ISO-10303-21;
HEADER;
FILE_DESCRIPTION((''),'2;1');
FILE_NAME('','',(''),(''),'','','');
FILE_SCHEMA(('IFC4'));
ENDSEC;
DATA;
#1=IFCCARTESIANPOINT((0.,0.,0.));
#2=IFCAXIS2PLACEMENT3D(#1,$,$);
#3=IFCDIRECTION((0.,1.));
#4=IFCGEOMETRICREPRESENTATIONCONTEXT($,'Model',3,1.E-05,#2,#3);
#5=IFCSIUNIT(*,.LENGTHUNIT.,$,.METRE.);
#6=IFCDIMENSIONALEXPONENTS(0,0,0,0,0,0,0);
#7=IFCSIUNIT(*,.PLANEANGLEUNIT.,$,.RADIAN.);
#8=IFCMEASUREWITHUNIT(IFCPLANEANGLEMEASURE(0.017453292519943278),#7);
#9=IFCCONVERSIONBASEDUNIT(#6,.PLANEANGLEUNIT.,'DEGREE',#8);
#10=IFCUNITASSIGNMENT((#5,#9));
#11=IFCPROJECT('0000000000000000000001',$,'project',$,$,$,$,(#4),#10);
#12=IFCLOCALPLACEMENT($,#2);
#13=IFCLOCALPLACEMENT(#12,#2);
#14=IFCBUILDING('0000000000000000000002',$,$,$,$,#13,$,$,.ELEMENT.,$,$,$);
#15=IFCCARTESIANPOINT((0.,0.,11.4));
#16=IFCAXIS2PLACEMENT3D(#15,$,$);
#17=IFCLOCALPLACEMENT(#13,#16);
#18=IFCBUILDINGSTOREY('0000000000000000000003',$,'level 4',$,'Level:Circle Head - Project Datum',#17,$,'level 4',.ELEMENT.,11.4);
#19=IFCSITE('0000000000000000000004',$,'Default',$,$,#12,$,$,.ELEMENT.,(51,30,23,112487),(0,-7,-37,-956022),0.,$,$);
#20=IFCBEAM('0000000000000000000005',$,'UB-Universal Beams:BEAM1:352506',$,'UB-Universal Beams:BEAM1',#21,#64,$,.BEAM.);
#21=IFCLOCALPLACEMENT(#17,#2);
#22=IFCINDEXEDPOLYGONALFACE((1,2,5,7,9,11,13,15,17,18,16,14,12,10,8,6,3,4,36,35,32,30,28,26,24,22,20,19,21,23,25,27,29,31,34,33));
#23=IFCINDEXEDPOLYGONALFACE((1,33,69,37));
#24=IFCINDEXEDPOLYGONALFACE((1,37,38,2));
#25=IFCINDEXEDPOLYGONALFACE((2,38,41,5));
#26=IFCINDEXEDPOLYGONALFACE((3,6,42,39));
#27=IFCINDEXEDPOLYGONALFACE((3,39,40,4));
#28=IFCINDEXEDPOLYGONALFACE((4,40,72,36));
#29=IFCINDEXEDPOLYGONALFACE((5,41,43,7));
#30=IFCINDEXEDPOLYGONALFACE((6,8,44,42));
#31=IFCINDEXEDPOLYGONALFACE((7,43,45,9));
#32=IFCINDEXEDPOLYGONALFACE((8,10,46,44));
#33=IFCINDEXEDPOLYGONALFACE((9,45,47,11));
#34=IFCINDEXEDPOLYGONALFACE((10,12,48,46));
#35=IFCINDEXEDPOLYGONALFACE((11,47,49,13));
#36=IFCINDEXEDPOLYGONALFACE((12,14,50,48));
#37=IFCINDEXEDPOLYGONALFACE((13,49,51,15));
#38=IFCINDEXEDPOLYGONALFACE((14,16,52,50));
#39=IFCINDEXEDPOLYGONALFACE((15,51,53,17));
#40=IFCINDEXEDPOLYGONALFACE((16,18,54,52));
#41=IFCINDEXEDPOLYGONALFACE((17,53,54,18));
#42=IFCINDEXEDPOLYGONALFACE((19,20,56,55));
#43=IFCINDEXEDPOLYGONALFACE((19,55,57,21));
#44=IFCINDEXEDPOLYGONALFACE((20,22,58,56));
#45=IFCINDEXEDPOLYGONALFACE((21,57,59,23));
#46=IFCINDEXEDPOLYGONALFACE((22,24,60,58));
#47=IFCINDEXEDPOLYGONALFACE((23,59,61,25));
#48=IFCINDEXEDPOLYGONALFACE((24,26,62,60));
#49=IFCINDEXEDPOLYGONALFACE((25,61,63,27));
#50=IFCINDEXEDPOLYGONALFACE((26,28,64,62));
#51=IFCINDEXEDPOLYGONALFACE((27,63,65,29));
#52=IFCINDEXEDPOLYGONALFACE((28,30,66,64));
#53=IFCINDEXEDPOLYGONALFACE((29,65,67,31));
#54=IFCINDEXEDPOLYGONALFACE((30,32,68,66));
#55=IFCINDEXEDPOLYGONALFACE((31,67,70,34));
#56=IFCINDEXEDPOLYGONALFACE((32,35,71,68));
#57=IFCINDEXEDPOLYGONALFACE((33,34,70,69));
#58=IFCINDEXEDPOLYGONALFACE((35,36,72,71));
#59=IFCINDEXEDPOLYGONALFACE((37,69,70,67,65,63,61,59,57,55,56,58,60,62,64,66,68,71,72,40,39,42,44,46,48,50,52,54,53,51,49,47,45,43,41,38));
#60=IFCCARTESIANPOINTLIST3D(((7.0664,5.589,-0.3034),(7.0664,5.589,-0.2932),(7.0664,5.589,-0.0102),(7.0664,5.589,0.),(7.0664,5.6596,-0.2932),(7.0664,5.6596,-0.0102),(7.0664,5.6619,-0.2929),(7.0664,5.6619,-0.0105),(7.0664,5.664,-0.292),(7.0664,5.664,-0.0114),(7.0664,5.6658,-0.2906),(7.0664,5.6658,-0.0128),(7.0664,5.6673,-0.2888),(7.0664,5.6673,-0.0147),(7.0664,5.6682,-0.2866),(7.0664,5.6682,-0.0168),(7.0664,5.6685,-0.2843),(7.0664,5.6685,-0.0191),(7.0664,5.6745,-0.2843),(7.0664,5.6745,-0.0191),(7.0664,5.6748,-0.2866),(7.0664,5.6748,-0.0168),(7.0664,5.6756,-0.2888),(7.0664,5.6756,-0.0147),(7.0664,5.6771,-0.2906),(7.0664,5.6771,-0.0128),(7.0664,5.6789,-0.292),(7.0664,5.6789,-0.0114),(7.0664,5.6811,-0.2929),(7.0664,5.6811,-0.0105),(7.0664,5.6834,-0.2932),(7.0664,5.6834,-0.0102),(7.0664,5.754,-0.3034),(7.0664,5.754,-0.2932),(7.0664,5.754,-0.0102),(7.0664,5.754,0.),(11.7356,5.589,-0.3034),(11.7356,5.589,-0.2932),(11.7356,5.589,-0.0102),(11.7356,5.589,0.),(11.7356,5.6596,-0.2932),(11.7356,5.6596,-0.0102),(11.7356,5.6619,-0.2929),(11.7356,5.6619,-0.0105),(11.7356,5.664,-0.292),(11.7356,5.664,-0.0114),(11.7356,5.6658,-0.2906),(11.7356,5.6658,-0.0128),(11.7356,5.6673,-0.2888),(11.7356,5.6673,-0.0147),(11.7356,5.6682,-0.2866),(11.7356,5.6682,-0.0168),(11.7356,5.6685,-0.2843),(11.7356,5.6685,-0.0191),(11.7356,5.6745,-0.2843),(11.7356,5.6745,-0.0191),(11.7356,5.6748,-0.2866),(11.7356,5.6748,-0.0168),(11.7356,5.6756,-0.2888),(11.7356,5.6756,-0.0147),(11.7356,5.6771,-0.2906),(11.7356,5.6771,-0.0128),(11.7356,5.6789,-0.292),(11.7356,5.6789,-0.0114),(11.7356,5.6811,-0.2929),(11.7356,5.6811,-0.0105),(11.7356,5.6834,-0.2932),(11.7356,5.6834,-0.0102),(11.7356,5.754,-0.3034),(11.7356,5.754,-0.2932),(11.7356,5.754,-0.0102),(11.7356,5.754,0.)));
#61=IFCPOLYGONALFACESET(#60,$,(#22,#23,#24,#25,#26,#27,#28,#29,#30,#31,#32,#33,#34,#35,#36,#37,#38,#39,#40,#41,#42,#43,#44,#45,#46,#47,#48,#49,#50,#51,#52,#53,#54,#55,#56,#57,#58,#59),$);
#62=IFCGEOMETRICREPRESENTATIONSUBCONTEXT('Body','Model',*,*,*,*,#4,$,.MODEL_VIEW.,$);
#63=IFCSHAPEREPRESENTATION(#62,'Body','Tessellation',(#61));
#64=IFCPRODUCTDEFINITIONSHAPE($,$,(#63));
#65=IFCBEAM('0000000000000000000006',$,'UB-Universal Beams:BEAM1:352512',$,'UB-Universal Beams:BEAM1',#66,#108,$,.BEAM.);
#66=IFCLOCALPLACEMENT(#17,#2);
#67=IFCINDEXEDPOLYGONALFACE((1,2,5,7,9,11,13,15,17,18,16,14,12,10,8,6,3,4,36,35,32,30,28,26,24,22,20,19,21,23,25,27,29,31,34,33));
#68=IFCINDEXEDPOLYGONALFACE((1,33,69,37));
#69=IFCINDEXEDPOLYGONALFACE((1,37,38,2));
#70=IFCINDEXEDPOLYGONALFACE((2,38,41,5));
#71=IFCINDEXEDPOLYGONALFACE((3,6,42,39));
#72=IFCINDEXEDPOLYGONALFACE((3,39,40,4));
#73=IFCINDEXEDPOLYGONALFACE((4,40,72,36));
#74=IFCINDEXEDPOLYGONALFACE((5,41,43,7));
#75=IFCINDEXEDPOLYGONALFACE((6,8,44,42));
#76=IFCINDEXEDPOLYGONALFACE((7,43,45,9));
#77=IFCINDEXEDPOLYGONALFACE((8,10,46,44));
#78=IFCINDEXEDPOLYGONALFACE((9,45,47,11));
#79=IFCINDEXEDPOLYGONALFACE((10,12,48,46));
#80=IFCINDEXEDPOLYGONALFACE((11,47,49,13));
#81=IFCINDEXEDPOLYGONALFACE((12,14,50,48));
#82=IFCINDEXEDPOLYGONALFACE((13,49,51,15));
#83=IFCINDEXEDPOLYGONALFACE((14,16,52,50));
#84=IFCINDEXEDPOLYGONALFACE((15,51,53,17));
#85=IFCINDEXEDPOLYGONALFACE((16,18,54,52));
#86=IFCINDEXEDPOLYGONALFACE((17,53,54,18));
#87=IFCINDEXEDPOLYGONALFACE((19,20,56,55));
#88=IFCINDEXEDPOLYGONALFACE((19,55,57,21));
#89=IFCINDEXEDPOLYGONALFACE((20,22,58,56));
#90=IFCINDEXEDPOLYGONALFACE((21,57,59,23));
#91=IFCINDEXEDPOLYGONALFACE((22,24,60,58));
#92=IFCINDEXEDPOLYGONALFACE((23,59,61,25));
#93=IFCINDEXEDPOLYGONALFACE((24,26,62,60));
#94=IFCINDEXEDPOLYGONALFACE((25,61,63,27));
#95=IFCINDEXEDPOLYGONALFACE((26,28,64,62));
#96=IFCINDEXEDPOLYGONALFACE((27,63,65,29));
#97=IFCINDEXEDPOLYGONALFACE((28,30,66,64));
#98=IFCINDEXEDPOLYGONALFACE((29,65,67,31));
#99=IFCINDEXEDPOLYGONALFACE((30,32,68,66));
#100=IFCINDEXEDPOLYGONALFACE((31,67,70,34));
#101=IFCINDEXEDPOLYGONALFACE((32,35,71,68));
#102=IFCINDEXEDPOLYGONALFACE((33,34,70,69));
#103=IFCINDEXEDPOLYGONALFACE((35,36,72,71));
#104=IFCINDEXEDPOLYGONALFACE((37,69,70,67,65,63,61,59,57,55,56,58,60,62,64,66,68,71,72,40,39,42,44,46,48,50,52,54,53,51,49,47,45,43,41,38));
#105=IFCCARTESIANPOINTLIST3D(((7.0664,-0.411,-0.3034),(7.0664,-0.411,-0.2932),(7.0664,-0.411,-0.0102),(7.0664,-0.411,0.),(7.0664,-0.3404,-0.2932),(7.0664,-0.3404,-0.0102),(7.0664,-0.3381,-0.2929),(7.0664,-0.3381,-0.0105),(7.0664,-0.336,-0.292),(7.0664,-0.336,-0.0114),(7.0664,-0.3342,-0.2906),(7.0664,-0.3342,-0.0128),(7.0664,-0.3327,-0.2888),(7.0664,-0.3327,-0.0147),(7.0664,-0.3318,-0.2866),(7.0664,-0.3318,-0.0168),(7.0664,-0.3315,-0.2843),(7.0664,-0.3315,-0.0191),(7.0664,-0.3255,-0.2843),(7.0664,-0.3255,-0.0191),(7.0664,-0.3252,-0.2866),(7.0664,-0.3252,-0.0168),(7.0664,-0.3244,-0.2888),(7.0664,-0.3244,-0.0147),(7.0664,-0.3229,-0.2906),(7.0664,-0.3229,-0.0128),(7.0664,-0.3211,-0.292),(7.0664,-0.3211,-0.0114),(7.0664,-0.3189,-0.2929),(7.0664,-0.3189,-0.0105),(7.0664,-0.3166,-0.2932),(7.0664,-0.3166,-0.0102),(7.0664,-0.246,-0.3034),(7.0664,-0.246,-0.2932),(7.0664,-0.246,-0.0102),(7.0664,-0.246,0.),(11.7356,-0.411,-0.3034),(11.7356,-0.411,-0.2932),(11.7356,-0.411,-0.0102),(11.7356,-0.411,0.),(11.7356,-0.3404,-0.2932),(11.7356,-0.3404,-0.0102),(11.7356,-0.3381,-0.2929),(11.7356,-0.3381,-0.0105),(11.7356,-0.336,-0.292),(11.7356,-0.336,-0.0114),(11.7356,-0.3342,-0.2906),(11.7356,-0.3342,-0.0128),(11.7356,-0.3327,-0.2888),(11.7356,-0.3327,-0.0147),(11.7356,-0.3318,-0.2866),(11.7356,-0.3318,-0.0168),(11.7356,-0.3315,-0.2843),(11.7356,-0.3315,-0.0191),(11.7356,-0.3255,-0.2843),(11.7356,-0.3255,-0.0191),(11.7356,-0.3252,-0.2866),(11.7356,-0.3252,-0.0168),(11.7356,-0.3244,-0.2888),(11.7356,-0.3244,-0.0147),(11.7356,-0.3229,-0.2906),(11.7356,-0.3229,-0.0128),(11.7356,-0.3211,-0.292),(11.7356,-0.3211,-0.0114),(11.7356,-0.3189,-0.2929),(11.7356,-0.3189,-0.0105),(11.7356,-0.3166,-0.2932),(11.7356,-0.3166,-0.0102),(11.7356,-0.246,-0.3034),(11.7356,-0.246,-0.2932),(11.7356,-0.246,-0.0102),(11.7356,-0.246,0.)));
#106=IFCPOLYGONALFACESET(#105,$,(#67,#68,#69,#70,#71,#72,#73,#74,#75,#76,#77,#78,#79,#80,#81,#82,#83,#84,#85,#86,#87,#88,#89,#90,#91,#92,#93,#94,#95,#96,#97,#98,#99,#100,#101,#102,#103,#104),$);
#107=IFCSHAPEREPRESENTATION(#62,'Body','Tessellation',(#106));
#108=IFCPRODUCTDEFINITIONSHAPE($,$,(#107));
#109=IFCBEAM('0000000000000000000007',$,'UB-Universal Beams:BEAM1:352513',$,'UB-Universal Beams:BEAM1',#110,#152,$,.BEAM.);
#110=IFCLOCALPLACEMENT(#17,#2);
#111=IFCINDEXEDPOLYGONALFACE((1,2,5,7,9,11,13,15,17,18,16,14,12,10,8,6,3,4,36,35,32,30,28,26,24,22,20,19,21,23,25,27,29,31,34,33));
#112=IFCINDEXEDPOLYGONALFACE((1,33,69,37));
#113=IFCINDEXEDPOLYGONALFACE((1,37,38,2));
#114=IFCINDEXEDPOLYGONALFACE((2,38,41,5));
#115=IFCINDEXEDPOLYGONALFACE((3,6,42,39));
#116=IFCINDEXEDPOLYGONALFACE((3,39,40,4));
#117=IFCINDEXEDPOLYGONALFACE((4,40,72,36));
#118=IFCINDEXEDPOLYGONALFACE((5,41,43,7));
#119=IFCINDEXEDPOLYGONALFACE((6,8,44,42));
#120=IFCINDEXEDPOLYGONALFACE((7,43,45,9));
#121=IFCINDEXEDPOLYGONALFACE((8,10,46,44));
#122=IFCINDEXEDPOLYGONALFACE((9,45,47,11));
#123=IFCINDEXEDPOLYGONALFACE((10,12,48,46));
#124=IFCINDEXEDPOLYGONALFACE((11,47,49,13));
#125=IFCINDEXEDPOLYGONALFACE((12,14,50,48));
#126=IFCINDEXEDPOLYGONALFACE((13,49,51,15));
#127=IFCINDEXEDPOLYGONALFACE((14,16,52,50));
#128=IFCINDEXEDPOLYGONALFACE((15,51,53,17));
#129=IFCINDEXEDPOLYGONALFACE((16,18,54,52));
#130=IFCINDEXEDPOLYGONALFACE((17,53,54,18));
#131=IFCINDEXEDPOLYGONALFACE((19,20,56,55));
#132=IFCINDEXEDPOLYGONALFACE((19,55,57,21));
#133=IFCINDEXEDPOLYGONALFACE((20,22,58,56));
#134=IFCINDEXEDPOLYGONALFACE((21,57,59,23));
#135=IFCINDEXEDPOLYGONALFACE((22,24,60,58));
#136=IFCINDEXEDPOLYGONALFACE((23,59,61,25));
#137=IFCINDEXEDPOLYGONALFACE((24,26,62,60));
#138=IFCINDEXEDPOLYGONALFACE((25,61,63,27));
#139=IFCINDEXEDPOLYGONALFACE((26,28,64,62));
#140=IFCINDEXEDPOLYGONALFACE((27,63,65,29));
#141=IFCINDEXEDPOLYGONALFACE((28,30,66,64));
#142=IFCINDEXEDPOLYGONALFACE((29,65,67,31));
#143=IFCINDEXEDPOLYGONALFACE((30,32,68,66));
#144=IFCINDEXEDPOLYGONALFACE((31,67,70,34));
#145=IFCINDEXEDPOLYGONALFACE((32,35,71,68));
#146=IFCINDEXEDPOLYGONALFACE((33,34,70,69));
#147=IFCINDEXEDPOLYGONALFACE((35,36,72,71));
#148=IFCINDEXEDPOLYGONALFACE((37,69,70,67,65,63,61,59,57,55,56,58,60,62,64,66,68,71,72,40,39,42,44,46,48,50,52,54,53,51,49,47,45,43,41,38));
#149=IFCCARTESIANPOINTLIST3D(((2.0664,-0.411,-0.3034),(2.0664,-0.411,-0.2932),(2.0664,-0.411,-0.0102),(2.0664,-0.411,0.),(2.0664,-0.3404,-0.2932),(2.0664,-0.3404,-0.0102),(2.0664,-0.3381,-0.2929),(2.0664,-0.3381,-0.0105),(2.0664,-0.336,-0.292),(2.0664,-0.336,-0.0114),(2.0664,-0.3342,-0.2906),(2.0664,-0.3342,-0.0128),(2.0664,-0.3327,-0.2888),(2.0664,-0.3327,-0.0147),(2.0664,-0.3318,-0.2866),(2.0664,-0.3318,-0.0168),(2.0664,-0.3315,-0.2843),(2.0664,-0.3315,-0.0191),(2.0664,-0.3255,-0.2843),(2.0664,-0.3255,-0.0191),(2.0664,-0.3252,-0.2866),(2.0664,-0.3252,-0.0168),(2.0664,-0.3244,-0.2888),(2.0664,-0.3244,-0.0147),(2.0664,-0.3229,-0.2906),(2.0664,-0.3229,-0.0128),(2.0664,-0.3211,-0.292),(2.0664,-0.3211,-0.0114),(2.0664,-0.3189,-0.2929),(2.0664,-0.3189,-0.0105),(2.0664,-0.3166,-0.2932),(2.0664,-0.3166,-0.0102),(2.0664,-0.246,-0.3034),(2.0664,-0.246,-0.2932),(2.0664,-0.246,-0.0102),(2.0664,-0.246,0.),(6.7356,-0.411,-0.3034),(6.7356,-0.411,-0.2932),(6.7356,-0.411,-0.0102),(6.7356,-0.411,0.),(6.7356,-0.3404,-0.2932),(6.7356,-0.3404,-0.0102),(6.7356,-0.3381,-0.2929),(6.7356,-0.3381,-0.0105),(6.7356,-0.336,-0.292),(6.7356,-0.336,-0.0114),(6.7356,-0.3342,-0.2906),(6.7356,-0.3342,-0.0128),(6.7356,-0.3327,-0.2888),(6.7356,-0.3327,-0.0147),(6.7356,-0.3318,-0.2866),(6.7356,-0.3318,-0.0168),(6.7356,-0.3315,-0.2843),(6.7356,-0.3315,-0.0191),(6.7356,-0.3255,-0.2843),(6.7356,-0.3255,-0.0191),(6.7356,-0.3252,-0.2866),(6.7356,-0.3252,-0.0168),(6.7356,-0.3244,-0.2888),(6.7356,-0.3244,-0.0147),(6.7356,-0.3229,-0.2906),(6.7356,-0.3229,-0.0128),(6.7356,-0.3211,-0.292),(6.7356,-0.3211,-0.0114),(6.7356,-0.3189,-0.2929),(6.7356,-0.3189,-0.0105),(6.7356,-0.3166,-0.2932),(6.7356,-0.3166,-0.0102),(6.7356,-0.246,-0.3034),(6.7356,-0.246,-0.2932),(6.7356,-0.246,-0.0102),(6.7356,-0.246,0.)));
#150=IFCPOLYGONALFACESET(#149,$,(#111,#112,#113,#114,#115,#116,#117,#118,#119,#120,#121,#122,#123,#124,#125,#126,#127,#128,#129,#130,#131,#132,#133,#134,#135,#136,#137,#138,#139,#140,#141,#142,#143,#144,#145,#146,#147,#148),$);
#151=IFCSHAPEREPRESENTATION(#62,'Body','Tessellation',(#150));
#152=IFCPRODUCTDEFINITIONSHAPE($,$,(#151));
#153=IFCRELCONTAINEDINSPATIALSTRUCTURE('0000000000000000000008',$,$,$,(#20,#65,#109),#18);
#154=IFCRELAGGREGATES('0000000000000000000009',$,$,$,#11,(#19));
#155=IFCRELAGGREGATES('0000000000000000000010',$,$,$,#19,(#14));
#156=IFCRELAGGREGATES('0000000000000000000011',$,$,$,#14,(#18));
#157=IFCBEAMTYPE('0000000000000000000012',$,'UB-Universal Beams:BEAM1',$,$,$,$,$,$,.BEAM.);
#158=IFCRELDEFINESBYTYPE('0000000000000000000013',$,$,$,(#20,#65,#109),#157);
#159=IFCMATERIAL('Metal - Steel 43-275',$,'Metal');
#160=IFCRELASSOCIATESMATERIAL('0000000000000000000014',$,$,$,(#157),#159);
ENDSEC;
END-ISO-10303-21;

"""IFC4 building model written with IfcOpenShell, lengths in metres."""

from ifc_helpers import new_model, entity, si_unit, converted_unit, direction, frame, frame_2d, origin, place, context, subcontext, project, spatial, polyline, circle_curve, parameter, trimmed, segment, composite_curve, outline, extrude, source, transform, mapped, material, material_profile, profile_set, type_object, type_shapes, element, save


model = new_model("IFC4")

# Units and contexts
model_context = context("Model", 3, precision=1e-05, world=origin(), true_north=direction((0.0, 1.0)))
body_context = subcontext(model_context, "Body", "Model", "MODEL_VIEW")
ifc_project = project(units=[si_unit("LENGTHUNIT", "METRE"), converted_unit("PLANEANGLEUNIT", "DEGREE", entity("IfcPlaneAngleMeasure", 0.017453292519943278), si_unit("PLANEANGLEUNIT", "RADIAN"), dimensions=[0, 0, 0, 0, 0, 0, 0])], contexts=[model_context])

# Site, building, storey
site_placement = place(None, origin())
site = spatial("IfcSite", under=ifc_project, at=site_placement, Name="Default", CompositionType="ELEMENT", RefLatitude=(51, 30, 23, 112487), RefLongitude=(0, -7, -37, -956022), RefElevation=0.0)
building_placement = place(site_placement, origin())
building = spatial("IfcBuilding", under=site, at=building_placement, CompositionType="ELEMENT")
storey_placement = place(building_placement, frame((0.0, 0.0, 11.4)))
storey = spatial("IfcBuildingStorey", under=building, at=storey_placement, Name="level 4", ObjectType="Level:Circle Head - Project Datum", LongName="level 4", CompositionType="ELEMENT", Elevation=11.4)

# Shared definitions
ifc_material_1 = material(Name="Metal - Steel 43-275", Category="Metal")

# Beams
ifc_material_profile_1 = material_profile(ifc_material_1, outline(composite_curve([segment(polyline([(-0.0825, -0.1415), (-0.0825, -0.1517)]), True, "CONTINUOUS"), segment(polyline([(-0.0825, -0.1517), (0.0825, -0.1517)]), True, "CONTINUOUS"), segment(polyline([(0.0825, -0.1517), (0.0825, -0.1415)]), True, "CONTINUOUS"), segment(polyline([(0.0825, -0.1415), (0.0119, -0.1415)]), True, "CONTINUOUS"), segment(trimmed(circle_curve(frame_2d((0.0119, -0.1326), x_axis=(1.0, 0.0)), 0.0089), [parameter(180.0)], [parameter(270.0)], True, "PARAMETER"), False, "CONTINUOUS"), segment(polyline([(0.003, -0.1326), (0.003, 0.1326)]), True, "CONTINUOUS"), segment(trimmed(circle_curve(frame_2d((0.0119, 0.1326), x_axis=(1.0, 0.0)), 0.0089), [parameter(90.0)], [parameter(180.0)], True, "PARAMETER"), False, "CONTINUOUS"), segment(polyline([(0.0119, 0.1415), (0.0825, 0.1415)]), True, "CONTINUOUS"), segment(polyline([(0.0825, 0.1415), (0.0825, 0.1517)]), True, "CONTINUOUS"), segment(polyline([(0.0825, 0.1517), (-0.0825, 0.1517)]), True, "CONTINUOUS"), segment(polyline([(-0.0825, 0.1517), (-0.0825, 0.1415)]), True, "CONTINUOUS"), segment(polyline([(-0.0825, 0.1415), (-0.0119, 0.1415)]), True, "CONTINUOUS"), segment(trimmed(circle_curve(frame_2d((-0.0119, 0.1326), x_axis=(1.0, 0.0)), 0.0089), [parameter(360.0)], [parameter(90.0)], True, "PARAMETER"), False, "CONTINUOUS"), segment(polyline([(-0.003, 0.1326), (-0.003, -0.1326)]), True, "CONTINUOUS"), segment(trimmed(circle_curve(frame_2d((-0.0119, -0.1326), x_axis=(1.0, 0.0)), 0.0089), [parameter(270.0)], [parameter(360.0)], True, "PARAMETER"), False, "CONTINUOUS"), segment(polyline([(-0.0119, -0.1415), (-0.0825, -0.1415)]), True, "CONTINUOUS")], self_intersect=False)), Name="BEAM1")
ifc_profile_set_1 = profile_set([ifc_material_profile_1], Name="BEAM1")
beam_type_1 = type_object("IfcBeamType", Name="UB-Universal Beams:BEAM1", PredefinedType="BEAM", material=ifc_profile_set_1)
shared_shape_1 = source(origin(), body_context, "Body", "SweptSolid", [
    extrude(outline(composite_curve([segment(polyline([(-0.0825, -0.1415), (-0.0825, -0.1517)]), True, "CONTINUOUS"), segment(polyline([(-0.0825, -0.1517), (0.0825, -0.1517)]), True, "CONTINUOUS"), segment(polyline([(0.0825, -0.1517), (0.0825, -0.1415)]), True, "CONTINUOUS"), segment(polyline([(0.0825, -0.1415), (0.0119, -0.1415)]), True, "CONTINUOUS"), segment(trimmed(circle_curve(frame_2d((0.0119, -0.1326), x_axis=(1.0, 0.0)), 0.0089), [parameter(180.0)], [parameter(270.0)], True, "PARAMETER"), False, "CONTINUOUS"), segment(polyline([(0.003, -0.1326), (0.003, 0.1326)]), True, "CONTINUOUS"), segment(trimmed(circle_curve(frame_2d((0.0119, 0.1326), x_axis=(1.0, 0.0)), 0.0089), [parameter(90.0)], [parameter(180.0)], True, "PARAMETER"), False, "CONTINUOUS"), segment(polyline([(0.0119, 0.1415), (0.0825, 0.1415)]), True, "CONTINUOUS"), segment(polyline([(0.0825, 0.1415), (0.0825, 0.1517)]), True, "CONTINUOUS"), segment(polyline([(0.0825, 0.1517), (-0.0825, 0.1517)]), True, "CONTINUOUS"), segment(polyline([(-0.0825, 0.1517), (-0.0825, 0.1415)]), True, "CONTINUOUS"), segment(polyline([(-0.0825, 0.1415), (-0.0119, 0.1415)]), True, "CONTINUOUS"), segment(trimmed(circle_curve(frame_2d((-0.0119, 0.1326), x_axis=(1.0, 0.0)), 0.0089), [parameter(360.0)], [parameter(90.0)], True, "PARAMETER"), False, "CONTINUOUS"), segment(polyline([(-0.003, 0.1326), (-0.003, -0.1326)]), True, "CONTINUOUS"), segment(trimmed(circle_curve(frame_2d((-0.0119, -0.1326), x_axis=(1.0, 0.0)), 0.0089), [parameter(270.0)], [parameter(360.0)], True, "PARAMETER"), False, "CONTINUOUS"), segment(polyline([(-0.0119, -0.1415), (-0.0825, -0.1415)]), True, "CONTINUOUS")], self_intersect=False)), frame((-2.3346, 0.0, 0.0), z_axis=(-1.0, 0.0, 0.0), x_axis=(0.0, -1.0, 0.0)), (0.0, 0.0, -1.0), 4.6692),
])
type_shapes(beam_type_1, [shared_shape_1])
for number, where, name in (
    (1, (9.401, 5.6715, -0.1517), "UB-Universal Beams:BEAM1:352506"),
    (2, (9.401, -0.3285, -0.1517), "UB-Universal Beams:BEAM1:352512"),
    (3, (4.401, -0.3285, -0.1517), "UB-Universal Beams:BEAM1:352513"),
):
    element("IfcBeam", number, at=place(storey_placement, frame(where)), inside=storey, type_object=beam_type_1, Name=name, ObjectType="UB-Universal Beams:BEAM1", PredefinedType="BEAM", context=body_context, shape_type="MappedRepresentation", body=[
        mapped(shared_shape_1, transform((0.0, 0.0, 0.0), scale=1.0)),
    ])

save(model, "model.ifc")
